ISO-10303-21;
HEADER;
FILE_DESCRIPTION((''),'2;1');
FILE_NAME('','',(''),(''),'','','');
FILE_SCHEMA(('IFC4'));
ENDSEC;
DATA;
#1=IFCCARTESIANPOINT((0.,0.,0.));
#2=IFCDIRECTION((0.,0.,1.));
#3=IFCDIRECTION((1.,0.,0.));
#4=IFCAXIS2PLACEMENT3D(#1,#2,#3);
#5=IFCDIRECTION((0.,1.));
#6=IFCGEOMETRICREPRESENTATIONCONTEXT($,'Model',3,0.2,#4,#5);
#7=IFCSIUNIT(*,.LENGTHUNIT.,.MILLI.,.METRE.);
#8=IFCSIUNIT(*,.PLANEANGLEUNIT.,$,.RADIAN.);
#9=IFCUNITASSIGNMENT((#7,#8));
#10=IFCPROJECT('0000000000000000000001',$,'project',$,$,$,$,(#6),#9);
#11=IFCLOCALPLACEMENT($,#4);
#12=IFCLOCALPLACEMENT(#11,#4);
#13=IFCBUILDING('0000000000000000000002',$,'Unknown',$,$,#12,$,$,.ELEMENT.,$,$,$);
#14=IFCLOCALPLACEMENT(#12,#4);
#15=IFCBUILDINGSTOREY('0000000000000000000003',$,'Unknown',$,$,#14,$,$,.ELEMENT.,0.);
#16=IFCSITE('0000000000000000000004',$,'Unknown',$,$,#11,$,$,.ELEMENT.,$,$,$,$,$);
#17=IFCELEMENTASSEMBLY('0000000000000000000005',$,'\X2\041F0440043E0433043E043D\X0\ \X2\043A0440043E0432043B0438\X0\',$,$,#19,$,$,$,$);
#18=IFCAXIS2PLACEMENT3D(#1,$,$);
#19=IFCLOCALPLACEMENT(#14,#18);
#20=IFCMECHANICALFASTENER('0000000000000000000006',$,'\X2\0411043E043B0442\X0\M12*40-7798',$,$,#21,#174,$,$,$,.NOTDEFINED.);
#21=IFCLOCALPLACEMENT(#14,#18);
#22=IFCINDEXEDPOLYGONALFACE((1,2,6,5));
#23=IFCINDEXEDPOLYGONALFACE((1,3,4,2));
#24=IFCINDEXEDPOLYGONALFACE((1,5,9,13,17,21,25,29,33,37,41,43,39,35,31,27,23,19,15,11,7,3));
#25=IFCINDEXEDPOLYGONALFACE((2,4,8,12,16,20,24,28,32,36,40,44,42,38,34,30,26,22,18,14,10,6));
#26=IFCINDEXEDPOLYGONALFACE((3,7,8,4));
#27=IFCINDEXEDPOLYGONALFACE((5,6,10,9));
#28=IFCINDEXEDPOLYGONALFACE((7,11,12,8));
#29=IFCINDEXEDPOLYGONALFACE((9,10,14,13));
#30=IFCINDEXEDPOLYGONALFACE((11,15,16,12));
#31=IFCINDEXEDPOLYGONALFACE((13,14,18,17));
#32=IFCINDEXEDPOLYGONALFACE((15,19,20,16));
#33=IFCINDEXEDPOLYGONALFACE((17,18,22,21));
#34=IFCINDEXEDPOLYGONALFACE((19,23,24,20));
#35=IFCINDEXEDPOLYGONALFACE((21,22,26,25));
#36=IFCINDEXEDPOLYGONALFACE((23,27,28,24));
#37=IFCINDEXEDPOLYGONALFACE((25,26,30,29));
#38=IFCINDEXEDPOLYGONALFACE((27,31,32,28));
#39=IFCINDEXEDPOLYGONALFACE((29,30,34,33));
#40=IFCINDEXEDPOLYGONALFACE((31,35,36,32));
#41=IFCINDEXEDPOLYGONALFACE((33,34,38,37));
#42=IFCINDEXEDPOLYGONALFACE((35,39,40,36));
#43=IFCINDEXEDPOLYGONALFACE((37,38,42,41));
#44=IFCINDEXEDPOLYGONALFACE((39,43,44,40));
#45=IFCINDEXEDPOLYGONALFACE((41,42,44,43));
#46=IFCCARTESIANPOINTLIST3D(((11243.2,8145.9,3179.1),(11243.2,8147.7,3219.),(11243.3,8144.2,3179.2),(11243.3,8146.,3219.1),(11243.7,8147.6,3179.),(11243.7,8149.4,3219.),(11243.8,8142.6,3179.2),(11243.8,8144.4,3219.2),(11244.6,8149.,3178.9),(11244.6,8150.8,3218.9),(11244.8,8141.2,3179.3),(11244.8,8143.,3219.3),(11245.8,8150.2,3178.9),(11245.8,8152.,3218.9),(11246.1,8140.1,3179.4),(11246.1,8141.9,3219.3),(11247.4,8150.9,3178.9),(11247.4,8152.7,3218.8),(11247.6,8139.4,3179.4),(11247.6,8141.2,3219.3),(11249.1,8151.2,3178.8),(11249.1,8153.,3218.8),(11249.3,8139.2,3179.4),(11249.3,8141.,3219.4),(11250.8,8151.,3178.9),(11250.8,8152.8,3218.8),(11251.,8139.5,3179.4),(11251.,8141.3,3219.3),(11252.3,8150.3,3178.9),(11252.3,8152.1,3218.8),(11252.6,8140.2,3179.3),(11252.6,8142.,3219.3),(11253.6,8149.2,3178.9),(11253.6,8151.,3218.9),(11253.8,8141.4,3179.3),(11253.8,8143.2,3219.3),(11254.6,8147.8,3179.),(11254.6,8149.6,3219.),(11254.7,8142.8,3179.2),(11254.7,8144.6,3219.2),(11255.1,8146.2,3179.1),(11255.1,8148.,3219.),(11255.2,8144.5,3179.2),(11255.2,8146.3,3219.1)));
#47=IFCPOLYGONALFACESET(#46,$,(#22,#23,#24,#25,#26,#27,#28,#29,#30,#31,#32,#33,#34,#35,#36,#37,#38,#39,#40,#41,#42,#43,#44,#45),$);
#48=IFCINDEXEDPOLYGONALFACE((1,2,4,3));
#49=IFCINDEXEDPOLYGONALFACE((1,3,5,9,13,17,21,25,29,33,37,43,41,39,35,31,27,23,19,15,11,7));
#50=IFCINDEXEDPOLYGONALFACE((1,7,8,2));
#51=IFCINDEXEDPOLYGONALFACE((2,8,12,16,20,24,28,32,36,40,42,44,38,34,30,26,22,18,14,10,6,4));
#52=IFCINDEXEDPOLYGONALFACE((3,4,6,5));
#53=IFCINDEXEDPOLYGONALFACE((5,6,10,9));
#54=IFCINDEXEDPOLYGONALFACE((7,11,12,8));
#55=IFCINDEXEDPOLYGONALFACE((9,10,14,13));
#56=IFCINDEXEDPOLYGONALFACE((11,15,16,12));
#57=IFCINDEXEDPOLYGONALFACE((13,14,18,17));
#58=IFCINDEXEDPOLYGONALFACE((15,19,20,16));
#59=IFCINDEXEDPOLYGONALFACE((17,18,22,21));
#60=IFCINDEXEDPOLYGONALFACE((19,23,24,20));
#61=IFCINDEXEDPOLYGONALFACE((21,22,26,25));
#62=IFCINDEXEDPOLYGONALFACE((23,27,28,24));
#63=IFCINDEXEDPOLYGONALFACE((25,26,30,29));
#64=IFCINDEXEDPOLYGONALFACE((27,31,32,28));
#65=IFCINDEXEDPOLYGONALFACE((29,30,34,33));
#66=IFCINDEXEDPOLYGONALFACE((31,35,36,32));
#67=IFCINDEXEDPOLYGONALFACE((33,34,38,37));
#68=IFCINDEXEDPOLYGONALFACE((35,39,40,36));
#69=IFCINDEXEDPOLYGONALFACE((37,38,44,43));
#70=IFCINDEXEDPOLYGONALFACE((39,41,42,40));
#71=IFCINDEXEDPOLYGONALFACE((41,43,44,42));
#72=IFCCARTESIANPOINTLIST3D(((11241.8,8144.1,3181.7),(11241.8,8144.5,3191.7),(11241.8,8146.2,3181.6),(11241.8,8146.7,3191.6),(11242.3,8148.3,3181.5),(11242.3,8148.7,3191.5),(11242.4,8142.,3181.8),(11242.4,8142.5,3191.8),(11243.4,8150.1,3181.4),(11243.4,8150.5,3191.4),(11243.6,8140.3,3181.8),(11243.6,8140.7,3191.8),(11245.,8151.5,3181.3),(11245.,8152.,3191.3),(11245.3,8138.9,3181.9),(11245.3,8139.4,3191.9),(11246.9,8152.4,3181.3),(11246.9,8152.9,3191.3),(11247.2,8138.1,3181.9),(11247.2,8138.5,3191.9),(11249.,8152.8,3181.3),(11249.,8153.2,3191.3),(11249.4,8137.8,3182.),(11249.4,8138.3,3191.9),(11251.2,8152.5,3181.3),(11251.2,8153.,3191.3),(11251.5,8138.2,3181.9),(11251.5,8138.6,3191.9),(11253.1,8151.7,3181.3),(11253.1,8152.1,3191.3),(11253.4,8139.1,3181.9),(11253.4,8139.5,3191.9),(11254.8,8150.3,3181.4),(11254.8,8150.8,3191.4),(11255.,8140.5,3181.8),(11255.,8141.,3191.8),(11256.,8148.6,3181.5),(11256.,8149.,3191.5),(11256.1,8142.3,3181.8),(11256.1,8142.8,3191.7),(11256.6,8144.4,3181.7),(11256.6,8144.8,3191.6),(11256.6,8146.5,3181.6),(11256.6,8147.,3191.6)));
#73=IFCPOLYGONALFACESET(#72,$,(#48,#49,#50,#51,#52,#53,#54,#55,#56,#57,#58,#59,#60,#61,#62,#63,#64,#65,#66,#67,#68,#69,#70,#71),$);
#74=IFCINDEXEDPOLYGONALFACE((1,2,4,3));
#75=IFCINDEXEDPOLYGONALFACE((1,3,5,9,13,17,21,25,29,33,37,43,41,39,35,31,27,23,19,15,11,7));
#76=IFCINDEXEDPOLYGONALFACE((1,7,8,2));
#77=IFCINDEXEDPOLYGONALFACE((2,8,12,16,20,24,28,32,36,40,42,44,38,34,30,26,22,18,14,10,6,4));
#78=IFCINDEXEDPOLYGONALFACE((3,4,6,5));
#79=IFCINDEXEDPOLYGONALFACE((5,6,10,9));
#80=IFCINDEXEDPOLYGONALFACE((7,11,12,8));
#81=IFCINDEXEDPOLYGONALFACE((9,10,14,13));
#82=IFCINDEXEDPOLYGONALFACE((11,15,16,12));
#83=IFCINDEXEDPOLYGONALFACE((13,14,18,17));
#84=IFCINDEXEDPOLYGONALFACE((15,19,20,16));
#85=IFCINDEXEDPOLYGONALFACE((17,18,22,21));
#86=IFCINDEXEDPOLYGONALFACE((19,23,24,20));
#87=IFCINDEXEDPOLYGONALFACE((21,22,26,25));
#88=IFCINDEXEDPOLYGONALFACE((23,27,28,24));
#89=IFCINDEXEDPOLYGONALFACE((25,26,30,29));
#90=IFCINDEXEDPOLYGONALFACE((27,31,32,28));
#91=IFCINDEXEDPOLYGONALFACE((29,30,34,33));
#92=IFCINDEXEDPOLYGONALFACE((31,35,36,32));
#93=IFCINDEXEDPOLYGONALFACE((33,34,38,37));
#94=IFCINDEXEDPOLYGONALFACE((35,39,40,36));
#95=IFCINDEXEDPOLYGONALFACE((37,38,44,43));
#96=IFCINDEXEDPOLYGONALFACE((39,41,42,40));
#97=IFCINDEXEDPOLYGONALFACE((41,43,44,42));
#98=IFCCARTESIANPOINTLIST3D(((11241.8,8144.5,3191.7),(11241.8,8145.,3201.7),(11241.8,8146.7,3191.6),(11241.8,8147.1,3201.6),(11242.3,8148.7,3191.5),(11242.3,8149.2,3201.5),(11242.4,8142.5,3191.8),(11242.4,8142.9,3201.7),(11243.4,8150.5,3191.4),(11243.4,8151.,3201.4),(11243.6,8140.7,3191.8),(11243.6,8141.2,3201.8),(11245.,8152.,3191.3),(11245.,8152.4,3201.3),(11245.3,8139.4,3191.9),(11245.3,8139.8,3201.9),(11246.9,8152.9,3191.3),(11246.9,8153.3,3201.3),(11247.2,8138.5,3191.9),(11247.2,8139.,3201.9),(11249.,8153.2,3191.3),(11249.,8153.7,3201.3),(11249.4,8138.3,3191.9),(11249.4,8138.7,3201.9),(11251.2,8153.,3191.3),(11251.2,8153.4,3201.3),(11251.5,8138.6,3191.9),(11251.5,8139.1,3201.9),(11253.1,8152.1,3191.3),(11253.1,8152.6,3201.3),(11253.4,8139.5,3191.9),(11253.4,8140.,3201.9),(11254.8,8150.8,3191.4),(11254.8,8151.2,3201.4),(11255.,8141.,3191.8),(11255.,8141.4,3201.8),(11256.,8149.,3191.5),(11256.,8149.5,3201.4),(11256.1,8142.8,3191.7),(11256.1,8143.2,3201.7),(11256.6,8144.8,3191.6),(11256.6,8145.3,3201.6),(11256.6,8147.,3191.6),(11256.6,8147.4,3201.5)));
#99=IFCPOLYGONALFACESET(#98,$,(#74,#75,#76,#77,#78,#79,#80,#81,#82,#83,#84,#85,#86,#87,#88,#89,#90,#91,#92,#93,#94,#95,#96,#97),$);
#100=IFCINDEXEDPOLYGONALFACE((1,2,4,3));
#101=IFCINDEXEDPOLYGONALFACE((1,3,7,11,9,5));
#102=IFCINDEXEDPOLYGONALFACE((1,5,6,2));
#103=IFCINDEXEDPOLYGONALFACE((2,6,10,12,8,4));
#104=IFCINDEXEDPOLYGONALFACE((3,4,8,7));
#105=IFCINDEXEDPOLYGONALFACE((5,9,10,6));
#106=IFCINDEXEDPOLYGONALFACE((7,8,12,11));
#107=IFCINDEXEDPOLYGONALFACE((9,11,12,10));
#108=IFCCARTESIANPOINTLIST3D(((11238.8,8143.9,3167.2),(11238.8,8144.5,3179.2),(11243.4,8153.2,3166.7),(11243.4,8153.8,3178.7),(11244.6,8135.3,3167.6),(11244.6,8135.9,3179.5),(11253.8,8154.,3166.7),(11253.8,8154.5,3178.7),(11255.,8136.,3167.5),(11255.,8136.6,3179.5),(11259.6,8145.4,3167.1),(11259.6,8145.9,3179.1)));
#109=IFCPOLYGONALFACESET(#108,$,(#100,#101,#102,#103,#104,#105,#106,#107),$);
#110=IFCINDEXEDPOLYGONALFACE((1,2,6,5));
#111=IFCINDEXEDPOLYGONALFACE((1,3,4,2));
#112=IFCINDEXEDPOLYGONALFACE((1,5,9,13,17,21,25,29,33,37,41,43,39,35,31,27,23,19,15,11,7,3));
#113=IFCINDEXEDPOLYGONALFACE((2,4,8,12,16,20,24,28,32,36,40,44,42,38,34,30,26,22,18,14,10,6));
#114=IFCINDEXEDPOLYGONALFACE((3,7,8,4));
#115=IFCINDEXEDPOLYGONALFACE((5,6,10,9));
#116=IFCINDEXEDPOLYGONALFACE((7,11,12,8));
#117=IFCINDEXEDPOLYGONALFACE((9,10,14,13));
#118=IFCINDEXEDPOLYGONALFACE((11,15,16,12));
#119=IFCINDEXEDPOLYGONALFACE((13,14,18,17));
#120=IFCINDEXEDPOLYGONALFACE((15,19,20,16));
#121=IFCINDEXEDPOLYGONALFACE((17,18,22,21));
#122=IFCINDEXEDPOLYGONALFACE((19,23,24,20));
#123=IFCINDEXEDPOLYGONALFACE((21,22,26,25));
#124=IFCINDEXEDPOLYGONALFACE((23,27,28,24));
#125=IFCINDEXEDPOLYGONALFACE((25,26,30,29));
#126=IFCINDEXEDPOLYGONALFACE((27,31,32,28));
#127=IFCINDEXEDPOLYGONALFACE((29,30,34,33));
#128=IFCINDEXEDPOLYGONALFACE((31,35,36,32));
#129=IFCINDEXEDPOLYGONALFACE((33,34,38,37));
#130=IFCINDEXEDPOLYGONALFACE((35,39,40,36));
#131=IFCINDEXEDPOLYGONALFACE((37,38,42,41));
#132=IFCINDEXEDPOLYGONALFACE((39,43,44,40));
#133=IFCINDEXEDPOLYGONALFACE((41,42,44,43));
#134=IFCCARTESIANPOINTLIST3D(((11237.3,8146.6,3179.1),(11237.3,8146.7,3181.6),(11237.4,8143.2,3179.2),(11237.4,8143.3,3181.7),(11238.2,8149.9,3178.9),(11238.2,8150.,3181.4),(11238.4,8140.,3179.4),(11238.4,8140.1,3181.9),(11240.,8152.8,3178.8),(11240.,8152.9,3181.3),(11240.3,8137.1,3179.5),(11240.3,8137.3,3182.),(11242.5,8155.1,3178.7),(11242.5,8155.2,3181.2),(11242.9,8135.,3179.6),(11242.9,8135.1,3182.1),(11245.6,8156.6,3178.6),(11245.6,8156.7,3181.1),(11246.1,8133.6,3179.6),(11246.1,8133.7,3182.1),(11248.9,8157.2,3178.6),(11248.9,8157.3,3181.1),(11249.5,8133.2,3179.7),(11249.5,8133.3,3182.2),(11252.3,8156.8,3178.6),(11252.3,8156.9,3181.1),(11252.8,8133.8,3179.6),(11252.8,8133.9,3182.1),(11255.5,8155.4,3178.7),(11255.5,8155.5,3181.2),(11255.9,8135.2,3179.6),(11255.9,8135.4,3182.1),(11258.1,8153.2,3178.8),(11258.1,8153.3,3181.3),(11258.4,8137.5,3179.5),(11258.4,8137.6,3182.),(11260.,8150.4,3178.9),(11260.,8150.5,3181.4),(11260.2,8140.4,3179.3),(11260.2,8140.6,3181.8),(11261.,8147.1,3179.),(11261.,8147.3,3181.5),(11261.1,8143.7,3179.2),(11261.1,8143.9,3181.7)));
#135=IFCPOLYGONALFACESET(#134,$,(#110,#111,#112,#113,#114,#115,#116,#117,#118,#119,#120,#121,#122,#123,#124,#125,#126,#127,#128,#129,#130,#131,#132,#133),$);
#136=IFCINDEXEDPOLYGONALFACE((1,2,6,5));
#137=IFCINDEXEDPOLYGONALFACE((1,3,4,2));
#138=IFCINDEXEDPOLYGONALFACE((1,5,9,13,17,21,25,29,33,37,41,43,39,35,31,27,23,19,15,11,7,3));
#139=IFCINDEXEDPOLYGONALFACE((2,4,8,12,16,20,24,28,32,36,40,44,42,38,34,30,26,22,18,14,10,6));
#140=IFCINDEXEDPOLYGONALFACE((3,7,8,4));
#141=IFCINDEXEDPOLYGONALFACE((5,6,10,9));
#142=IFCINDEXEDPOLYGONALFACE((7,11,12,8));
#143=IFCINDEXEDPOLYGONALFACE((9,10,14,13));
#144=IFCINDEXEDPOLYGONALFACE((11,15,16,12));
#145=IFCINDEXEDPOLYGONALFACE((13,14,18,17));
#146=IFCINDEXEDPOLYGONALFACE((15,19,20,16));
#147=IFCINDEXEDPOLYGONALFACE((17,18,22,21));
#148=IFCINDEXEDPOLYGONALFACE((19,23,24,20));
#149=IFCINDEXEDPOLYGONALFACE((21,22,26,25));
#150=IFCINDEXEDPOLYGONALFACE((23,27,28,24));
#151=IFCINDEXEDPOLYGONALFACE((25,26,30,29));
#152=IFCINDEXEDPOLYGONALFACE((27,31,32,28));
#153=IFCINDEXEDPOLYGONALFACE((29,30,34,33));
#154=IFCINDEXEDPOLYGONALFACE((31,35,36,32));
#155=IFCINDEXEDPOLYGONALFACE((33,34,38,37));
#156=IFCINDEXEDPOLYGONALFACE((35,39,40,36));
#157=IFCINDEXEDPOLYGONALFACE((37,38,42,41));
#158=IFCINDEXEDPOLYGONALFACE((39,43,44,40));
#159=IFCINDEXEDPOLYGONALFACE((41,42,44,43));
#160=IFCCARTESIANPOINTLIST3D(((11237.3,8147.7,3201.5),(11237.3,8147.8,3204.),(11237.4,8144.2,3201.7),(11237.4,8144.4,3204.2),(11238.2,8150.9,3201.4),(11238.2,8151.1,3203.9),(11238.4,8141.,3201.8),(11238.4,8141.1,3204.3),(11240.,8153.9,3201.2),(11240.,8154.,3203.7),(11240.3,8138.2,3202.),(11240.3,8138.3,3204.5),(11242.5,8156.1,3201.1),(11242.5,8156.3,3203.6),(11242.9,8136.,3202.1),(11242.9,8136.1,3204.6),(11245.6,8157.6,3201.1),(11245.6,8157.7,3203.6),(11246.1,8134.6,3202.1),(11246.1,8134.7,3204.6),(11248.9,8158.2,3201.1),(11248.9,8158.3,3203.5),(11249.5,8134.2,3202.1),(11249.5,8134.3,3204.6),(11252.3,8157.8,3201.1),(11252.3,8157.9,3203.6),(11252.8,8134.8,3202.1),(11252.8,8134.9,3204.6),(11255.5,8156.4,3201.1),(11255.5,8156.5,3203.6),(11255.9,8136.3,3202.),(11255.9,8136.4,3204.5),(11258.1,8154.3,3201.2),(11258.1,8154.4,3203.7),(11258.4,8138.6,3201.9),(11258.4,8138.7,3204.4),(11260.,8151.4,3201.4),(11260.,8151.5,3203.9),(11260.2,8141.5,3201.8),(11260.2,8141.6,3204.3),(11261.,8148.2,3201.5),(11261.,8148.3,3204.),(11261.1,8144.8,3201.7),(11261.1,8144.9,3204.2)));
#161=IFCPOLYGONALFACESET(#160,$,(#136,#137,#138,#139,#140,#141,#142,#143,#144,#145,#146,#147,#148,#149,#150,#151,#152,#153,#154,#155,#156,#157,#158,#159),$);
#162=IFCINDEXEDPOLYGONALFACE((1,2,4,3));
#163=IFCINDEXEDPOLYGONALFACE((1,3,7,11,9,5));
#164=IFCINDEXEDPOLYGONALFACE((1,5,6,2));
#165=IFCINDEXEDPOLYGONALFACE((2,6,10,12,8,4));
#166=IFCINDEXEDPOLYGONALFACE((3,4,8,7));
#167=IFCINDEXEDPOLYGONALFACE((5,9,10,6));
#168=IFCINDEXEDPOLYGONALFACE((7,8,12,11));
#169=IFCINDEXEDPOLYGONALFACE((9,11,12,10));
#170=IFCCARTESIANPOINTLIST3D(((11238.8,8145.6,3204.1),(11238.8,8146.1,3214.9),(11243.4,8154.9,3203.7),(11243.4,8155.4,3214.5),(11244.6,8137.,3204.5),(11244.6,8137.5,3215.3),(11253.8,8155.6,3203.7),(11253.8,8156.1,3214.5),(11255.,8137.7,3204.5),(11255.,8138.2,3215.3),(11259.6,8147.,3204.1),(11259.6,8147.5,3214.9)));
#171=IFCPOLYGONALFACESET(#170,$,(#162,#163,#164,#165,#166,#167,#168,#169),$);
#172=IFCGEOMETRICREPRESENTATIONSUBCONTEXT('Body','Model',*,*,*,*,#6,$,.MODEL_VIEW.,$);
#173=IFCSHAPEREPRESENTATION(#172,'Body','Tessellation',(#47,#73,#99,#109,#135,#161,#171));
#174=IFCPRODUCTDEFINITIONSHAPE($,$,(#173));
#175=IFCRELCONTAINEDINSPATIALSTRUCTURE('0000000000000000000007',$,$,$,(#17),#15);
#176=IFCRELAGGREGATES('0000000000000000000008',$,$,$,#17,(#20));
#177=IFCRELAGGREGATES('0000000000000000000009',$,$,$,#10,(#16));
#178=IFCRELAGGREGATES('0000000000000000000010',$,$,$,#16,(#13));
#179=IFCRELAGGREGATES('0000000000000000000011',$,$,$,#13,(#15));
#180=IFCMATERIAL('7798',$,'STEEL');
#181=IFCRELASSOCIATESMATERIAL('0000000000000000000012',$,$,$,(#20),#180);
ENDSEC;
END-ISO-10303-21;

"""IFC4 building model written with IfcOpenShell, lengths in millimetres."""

from ifc_helpers import new_model, si_unit, direction, frame, origin_with_axes, place, context, subcontext, project, spatial, line, arc, indexed_curve, outline, extrude, source, transform, mapped, material, element, aggregate, save


model = new_model("IFC4")

# Units and contexts
model_context = context("Model", 3, precision=0.2, world=origin_with_axes(), true_north=direction((0.0, 1.0)))
body_context = subcontext(model_context, "Body", "Model", "MODEL_VIEW")
ifc_project = project(units=[si_unit("LENGTHUNIT", "METRE", prefix="MILLI"), si_unit("PLANEANGLEUNIT", "RADIAN")], contexts=[model_context])

# Site, building, storey
site_placement = place(None, origin_with_axes())
site = spatial("IfcSite", under=ifc_project, at=site_placement, Name="Unknown", CompositionType="ELEMENT")
building_placement = place(site_placement, origin_with_axes())
building = spatial("IfcBuilding", under=site, at=building_placement, Name="Unknown", CompositionType="ELEMENT")
storey_placement = place(building_placement, origin_with_axes())
storey = spatial("IfcBuildingStorey", under=building, at=storey_placement, Name="Unknown", CompositionType="ELEMENT", Elevation=0.0)

# Element assembly
assembly_1_placement = place(storey_placement, frame((5405.0, 8247.1, 3182.0), z_axis=(0.0, -0.998969, 0.045408), x_axis=(1.0, 0.0, 0.0)))
assembly_1 = element("IfcElementAssembly", 1, at=assembly_1_placement, inside=storey, Name="Прогон кровли")

# Mechanical fastener
ifc_material_1 = material(Name="7798", Category="STEEL")
shared_shape_1 = source(origin_with_axes(), body_context, "Body", "SweptSolid", [
    extrude(outline(indexed_curve([(6.0, 0.0), (0.0, 6.0), (-6.0, 0.0), (0.0, -6.0)], segments=[arc(1, 2, 3), arc(3, 4, 1)])), frame((0.0, 0.0, 2.5), z_axis=(0.0, 0.0, -1.0), x_axis=(0.0, 1.0, 0.0)), (0.0, 0.0, 1.0), 40.0),
    extrude(outline(indexed_curve([(7.5, 0.0), (0.0, 7.5), (-7.5, 0.0), (0.0, -7.5)], segments=[arc(1, 2, 3), arc(3, 4, 1)])), frame((0.0, 0.0, 0.0), z_axis=(0.0, 0.0, -1.0), x_axis=(0.0, 1.0, 0.0)), (0.0, 0.0, 1.0), 10.0),
    extrude(outline(indexed_curve([(7.5, 0.0), (0.0, 7.5), (-7.5, 0.0), (0.0, -7.5)], segments=[arc(1, 2, 3), arc(3, 4, 1)])), frame((0.0, 0.0, -10.0), z_axis=(0.0, 0.0, -1.0), x_axis=(0.0, 1.0, 0.0)), (0.0, 0.0, 1.0), 10.0),
    extrude(outline(indexed_curve([(10.4, 0.0), (5.2, 9.0), (-5.2, 9.0), (-10.4, 0.0), (-5.2, -9.0), (5.2, -9.0)], segments=[line(1, 2, 3, 4, 5, 6, 1)])), frame((0.0, 0.0, 14.5), z_axis=(0.0, 0.0, -1.0), x_axis=(0.0, 1.0, 0.0)), (0.0, 0.0, 1.0), 12.0),
    extrude(outline(indexed_curve([(12.0, 0.0), (0.0, 12.0), (-12.0, 0.0), (0.0, -12.0)], segments=[arc(1, 2, 3), arc(3, 4, 1)])), frame((0.0, 0.0, 2.5), z_axis=(0.0, 0.0, -1.0), x_axis=(0.0, 1.0, 0.0)), (0.0, 0.0, 1.0), 2.5),
    extrude(outline(indexed_curve([(12.0, 0.0), (0.0, 12.0), (-12.0, 0.0), (0.0, -12.0)], segments=[arc(1, 2, 3), arc(3, 4, 1)])), frame((0.0, 0.0, -20.0), z_axis=(0.0, 0.0, -1.0), x_axis=(0.0, 1.0, 0.0)), (0.0, 0.0, 1.0), 2.5),
    extrude(outline(indexed_curve([(10.4, 0.0), (5.2, 9.0), (-5.2, 9.0), (-10.4, 0.0), (-5.2, -9.0), (5.2, -9.0)], segments=[line(1, 2, 3, 4, 5, 6, 1)])), frame((0.0, 0.0, -22.5), z_axis=(0.0, 0.0, -1.0), x_axis=(0.0, 1.0, 0.0)), (0.0, 0.0, 1.0), 10.8),
])
mechanical_fastener_1_placement = place(assembly_1_placement, frame((5844.2, -5.0, 101.6), z_axis=(0.0, -1.0, 0.0), x_axis=(-0.829223, 0.0, 0.558918)))
mechanical_fastener_1 = element("IfcMechanicalFastener", 2, at=mechanical_fastener_1_placement, material=ifc_material_1, Name="БолтM12*40-7798", PredefinedType="NOTDEFINED", context=body_context, shape_type="MappedRepresentation", body=[
    mapped(shared_shape_1, transform((0.0, 0.0, 0.0))),
])
aggregate(assembly_1, [mechanical_fastener_1])

save(model, "model.ifc")
